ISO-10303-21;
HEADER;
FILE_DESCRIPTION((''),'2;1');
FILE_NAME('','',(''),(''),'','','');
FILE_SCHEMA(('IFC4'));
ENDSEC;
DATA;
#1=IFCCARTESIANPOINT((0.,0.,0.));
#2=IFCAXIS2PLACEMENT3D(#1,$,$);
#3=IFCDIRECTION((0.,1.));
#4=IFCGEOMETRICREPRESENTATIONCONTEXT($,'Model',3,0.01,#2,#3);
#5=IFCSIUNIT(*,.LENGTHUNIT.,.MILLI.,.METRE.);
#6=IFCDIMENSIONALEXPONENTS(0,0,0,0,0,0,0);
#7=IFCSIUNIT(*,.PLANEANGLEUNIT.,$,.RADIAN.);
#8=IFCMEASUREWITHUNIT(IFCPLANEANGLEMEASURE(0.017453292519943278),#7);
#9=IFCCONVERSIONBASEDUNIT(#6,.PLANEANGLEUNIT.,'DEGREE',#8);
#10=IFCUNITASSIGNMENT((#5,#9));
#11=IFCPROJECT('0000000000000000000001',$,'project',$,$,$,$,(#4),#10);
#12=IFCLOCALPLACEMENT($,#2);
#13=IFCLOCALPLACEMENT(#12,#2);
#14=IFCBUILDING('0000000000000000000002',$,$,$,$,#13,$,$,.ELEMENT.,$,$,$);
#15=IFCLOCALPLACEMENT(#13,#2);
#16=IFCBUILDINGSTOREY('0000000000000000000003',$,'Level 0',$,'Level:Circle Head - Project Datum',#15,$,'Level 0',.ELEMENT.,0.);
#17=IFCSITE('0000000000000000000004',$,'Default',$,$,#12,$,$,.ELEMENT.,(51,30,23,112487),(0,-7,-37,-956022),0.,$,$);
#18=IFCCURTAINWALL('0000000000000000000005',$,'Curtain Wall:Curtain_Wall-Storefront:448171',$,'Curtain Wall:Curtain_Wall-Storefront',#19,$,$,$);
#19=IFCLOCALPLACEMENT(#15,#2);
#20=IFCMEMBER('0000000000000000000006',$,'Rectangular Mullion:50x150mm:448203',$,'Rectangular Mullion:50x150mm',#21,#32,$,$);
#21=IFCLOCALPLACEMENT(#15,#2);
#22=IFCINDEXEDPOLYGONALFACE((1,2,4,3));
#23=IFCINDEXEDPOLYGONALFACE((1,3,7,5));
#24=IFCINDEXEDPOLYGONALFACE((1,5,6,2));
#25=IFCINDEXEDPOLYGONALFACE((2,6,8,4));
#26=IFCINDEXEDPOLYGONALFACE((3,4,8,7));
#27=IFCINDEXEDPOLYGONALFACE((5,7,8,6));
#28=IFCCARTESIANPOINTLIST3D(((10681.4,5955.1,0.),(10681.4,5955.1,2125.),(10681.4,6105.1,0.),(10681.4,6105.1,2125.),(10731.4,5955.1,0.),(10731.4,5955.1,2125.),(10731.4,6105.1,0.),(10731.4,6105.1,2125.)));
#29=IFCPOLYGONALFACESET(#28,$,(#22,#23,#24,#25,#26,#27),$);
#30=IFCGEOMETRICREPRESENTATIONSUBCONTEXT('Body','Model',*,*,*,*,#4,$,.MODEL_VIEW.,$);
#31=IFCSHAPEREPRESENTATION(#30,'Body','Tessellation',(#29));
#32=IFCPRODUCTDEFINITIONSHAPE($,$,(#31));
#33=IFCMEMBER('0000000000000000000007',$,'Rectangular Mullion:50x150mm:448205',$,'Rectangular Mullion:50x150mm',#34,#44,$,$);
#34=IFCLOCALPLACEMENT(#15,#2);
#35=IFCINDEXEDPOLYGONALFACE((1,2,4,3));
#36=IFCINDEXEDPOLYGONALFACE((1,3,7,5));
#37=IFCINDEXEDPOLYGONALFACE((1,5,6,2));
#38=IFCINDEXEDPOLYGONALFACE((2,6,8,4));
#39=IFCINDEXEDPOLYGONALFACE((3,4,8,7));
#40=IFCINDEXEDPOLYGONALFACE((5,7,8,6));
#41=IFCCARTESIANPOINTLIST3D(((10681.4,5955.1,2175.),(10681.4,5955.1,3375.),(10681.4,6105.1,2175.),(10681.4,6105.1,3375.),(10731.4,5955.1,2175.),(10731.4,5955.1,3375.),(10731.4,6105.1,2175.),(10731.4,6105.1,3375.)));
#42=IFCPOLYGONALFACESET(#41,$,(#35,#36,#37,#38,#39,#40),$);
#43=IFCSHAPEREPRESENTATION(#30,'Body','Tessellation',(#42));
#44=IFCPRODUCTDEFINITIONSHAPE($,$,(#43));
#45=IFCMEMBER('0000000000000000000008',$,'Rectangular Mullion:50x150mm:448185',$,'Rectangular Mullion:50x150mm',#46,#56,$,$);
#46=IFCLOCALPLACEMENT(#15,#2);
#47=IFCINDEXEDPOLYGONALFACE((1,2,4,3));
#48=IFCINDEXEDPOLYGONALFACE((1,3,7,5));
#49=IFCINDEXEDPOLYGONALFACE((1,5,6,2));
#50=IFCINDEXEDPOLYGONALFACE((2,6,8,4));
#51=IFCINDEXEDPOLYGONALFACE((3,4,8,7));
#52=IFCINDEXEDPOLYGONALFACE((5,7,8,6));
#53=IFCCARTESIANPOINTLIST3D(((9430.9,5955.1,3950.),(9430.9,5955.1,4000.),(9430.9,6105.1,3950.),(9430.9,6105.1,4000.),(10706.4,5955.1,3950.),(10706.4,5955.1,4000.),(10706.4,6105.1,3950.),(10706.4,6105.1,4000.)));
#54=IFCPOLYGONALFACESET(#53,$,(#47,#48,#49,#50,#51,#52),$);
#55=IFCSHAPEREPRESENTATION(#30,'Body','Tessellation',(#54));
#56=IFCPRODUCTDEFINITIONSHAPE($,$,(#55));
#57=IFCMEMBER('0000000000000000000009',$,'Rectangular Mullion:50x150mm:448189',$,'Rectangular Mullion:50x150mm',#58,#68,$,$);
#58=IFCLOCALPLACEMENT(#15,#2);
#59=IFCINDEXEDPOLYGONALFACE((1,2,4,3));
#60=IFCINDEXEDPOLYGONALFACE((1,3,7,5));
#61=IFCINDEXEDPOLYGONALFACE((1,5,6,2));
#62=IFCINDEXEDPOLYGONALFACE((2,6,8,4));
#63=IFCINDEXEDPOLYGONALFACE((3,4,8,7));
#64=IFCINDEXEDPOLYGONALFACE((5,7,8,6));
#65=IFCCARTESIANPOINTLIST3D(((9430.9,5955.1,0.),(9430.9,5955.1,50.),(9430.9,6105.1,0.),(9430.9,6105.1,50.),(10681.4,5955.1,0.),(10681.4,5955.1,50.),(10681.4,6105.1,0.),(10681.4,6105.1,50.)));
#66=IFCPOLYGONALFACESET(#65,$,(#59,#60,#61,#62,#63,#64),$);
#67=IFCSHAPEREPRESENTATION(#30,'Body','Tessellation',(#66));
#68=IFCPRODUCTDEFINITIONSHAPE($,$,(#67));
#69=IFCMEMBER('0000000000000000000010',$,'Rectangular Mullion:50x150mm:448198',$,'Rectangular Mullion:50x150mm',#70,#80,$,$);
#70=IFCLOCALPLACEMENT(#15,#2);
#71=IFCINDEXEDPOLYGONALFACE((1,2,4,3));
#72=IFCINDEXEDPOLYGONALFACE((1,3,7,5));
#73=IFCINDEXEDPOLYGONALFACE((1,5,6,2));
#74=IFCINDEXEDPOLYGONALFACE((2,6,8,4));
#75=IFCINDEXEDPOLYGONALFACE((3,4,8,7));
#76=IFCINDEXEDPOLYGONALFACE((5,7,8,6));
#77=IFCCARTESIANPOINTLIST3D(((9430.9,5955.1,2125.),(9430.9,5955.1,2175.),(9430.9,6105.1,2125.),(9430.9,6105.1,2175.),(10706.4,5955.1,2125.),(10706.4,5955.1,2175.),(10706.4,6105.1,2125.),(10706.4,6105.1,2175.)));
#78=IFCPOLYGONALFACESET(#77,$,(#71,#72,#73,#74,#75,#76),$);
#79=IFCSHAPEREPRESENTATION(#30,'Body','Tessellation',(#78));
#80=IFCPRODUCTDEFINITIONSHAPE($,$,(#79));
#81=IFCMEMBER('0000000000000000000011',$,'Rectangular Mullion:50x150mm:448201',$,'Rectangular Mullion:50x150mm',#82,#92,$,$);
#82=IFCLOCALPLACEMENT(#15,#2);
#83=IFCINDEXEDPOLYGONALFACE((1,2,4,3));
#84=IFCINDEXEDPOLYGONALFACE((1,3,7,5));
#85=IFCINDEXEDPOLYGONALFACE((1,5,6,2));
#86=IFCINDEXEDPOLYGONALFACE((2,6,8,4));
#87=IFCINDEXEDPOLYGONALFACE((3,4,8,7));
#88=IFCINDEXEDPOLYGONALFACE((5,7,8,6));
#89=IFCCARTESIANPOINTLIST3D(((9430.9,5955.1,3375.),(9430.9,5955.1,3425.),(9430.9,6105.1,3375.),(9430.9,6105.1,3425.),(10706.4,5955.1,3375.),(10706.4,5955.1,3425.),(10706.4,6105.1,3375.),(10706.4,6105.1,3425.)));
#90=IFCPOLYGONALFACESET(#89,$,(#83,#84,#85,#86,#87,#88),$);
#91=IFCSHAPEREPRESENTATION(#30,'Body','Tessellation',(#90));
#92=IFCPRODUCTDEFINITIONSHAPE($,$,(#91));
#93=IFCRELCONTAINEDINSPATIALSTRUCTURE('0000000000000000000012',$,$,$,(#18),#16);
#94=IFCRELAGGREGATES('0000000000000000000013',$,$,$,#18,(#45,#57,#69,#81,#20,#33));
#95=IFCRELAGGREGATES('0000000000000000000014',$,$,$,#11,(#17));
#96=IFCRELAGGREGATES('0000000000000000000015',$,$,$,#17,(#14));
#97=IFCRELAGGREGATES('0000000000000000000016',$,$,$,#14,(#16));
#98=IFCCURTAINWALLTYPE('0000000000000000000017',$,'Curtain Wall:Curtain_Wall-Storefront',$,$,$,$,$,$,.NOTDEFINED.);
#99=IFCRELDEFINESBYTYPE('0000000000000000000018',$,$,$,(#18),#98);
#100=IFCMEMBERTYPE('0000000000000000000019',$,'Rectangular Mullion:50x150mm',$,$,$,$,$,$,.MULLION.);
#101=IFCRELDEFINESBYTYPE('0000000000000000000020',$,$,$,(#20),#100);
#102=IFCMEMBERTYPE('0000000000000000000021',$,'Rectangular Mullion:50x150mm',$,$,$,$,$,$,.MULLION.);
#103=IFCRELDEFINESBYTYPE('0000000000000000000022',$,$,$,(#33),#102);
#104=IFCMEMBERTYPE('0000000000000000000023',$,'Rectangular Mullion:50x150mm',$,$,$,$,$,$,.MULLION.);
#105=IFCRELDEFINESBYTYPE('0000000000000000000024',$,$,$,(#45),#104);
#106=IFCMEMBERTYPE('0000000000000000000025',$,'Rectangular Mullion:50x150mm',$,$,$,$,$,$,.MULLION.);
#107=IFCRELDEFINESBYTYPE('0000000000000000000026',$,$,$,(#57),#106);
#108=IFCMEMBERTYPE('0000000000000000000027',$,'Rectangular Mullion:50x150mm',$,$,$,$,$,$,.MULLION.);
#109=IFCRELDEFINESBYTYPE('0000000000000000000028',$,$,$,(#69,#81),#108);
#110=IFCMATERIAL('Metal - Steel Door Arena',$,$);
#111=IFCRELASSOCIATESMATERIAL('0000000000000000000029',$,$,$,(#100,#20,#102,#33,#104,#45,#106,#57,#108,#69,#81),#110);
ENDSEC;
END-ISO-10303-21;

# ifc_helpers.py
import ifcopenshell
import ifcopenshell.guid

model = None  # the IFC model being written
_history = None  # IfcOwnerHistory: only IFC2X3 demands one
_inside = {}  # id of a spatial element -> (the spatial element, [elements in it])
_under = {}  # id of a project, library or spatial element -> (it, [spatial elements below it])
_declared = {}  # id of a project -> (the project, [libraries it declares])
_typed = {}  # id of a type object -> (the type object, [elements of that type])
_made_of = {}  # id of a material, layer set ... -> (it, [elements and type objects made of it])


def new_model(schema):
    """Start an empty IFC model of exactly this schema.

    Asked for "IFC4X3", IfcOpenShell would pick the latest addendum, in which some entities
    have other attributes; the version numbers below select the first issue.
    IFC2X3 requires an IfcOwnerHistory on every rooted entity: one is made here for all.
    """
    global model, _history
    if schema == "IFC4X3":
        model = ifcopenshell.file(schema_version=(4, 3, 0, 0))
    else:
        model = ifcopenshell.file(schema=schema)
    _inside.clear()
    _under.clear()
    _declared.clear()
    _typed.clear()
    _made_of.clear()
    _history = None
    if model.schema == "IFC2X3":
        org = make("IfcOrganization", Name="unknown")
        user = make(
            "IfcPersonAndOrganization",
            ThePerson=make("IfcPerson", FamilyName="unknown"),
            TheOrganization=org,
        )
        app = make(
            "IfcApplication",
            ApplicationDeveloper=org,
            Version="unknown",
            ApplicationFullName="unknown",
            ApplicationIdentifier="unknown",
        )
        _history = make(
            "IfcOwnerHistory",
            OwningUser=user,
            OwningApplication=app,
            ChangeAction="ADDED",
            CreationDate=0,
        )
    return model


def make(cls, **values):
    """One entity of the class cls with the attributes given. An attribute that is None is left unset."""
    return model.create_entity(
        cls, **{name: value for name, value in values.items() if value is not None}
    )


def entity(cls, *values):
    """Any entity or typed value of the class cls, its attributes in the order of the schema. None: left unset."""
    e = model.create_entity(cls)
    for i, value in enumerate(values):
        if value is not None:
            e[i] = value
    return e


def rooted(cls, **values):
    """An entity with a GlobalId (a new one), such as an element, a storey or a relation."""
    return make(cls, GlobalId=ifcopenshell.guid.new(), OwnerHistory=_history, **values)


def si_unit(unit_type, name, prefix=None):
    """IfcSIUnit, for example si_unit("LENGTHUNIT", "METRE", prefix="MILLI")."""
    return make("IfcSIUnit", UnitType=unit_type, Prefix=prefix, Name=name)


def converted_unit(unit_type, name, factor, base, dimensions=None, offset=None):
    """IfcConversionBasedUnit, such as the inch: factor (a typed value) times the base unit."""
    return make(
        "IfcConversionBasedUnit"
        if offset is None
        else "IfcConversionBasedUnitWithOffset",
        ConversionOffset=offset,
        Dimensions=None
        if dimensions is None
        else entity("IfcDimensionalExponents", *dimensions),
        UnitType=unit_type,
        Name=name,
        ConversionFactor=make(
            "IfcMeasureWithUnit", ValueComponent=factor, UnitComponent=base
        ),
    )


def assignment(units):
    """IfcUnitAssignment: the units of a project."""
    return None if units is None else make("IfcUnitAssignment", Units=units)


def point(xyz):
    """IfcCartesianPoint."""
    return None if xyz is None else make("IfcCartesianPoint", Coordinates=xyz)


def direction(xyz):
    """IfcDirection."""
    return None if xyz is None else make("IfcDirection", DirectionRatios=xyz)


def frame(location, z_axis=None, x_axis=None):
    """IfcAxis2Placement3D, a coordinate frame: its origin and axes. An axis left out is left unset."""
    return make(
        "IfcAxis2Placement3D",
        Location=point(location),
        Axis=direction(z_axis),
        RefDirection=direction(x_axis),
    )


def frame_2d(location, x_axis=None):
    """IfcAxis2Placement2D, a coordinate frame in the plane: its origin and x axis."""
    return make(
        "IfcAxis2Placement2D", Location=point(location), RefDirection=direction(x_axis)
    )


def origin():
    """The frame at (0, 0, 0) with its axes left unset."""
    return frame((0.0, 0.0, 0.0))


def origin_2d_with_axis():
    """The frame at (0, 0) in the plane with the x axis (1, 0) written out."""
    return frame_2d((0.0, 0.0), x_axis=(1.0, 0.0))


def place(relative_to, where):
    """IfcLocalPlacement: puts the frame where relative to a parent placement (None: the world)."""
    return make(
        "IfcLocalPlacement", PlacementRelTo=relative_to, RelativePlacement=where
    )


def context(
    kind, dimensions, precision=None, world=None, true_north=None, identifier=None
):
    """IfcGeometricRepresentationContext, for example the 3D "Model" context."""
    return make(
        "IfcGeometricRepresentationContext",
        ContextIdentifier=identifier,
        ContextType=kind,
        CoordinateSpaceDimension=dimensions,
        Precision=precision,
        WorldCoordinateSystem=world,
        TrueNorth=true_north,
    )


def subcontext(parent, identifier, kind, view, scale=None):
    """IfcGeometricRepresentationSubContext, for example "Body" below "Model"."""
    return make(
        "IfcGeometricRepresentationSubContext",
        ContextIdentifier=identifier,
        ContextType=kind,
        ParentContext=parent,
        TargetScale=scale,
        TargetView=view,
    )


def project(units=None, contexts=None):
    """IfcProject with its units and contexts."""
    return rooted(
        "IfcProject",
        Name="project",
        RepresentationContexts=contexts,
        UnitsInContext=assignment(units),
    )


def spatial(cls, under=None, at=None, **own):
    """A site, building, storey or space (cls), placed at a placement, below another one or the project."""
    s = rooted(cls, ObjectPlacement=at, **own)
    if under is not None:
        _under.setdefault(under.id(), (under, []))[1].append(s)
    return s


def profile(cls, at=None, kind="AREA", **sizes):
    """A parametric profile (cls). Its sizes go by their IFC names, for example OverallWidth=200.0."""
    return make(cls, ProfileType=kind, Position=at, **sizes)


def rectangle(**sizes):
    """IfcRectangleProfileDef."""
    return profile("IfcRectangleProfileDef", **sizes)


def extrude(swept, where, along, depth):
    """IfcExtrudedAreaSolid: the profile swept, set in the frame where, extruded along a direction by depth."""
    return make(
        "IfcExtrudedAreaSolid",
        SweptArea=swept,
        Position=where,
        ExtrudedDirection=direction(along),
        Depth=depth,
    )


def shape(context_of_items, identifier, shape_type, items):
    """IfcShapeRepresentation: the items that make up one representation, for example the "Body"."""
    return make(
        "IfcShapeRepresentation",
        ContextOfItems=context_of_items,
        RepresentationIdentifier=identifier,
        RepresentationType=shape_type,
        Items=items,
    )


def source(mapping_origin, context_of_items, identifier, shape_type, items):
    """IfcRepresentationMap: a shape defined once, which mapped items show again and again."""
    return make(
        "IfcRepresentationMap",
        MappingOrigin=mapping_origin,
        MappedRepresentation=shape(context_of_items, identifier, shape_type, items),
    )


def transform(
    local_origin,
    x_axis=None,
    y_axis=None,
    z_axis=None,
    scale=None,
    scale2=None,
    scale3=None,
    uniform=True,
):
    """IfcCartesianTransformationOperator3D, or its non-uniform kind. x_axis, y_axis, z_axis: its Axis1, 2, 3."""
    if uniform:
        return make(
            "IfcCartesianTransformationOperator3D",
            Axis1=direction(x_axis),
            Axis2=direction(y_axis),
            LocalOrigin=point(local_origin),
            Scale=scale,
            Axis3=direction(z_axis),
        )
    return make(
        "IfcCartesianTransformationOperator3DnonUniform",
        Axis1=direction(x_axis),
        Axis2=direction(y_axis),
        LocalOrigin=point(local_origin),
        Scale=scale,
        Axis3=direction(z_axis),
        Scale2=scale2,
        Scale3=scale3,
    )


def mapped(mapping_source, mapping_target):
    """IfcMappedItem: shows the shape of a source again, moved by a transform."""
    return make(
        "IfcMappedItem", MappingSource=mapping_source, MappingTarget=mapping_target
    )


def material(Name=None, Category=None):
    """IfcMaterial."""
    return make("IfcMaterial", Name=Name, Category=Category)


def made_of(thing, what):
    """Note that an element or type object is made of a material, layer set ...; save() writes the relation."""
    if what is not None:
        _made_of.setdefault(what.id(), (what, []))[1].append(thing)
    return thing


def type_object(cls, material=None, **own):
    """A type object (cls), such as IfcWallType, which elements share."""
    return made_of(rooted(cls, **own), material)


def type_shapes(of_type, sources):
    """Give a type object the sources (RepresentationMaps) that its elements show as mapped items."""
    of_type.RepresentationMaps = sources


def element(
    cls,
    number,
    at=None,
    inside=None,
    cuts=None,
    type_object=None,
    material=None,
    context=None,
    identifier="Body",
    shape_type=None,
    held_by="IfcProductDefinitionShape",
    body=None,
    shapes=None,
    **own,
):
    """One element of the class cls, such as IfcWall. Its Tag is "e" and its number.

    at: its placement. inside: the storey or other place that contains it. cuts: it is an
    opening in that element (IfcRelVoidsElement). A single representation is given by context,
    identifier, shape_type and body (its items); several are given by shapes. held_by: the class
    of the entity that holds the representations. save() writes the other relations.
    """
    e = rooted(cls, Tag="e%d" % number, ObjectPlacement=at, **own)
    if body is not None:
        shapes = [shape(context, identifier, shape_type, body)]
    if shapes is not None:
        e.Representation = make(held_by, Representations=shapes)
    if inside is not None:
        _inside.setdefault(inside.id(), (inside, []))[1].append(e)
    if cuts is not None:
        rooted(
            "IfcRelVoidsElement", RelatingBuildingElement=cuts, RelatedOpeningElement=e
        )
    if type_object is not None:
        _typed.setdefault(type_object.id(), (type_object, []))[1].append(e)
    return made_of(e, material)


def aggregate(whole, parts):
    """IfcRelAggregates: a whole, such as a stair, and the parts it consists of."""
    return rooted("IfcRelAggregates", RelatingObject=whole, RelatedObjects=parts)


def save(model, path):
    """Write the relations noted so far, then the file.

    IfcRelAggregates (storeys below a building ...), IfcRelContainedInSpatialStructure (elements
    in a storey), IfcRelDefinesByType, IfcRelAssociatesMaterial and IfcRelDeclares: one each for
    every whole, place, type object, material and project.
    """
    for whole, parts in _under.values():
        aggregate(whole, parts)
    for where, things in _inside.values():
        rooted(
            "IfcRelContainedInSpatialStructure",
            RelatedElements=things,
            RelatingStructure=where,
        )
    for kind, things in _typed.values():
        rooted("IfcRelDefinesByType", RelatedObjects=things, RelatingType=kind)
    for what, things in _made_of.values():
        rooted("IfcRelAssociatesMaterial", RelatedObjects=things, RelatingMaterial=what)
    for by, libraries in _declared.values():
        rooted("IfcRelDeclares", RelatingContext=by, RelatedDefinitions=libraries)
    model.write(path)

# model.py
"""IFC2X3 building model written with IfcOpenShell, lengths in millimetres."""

from ifc_helpers import new_model, entity, si_unit, converted_unit, direction, frame, origin, origin_2d_with_axis, place, context, subcontext, project, spatial, rectangle, extrude, source, transform, mapped, material, type_object, type_shapes, element, aggregate, save


model = new_model("IFC2X3")

# Units and contexts
model_context = context("Model", 3, precision=0.01, world=origin(), true_north=direction((0.0, 1.0)))
body_context = subcontext(model_context, "Body", "Model", "MODEL_VIEW")
ifc_project = project(units=[si_unit("LENGTHUNIT", "METRE", prefix="MILLI"), converted_unit("PLANEANGLEUNIT", "DEGREE", entity("IfcPlaneAngleMeasure", 0.017453292519943278), si_unit("PLANEANGLEUNIT", "RADIAN"), dimensions=[0, 0, 0, 0, 0, 0, 0])], contexts=[model_context])

# Site, building, storey
site_placement = place(None, origin())
site = spatial("IfcSite", under=ifc_project, at=site_placement, Name="Default", CompositionType="ELEMENT", RefLatitude=(51, 30, 23, 112487), RefLongitude=(0, -7, -37, -956022), RefElevation=0.0)
building_placement = place(site_placement, origin())
building = spatial("IfcBuilding", under=site, at=building_placement, CompositionType="ELEMENT")
storey_placement = place(building_placement, origin())
storey = spatial("IfcBuildingStorey", under=building, at=storey_placement, Name="Level 0", ObjectType="Level:Circle Head - Project Datum", LongName="Level 0", CompositionType="ELEMENT", Elevation=0.0)

# Curtain wall
curtain_wall_type = type_object("IfcCurtainWallType", Name="Curtain Wall:Curtain_Wall-Storefront", PredefinedType="NOTDEFINED")
curtain_wall_1_placement = place(storey_placement, origin())
curtain_wall_1 = element("IfcCurtainWall", 1, at=curtain_wall_1_placement, inside=storey, type_object=curtain_wall_type, Name="Curtain Wall:Curtain_Wall-Storefront:448171", ObjectType="Curtain Wall:Curtain_Wall-Storefront")
ifc_material_1 = material(Name="Metal - Steel Door Arena")

# Members
member_type_1 = type_object("IfcMemberType", Name="Rectangular Mullion:50x150mm", PredefinedType="MULLION", material=ifc_material_1)
shared_shape_1 = source(origin(), body_context, "Body", "SweptSolid", [
    extrude(rectangle(XDim=50.0, YDim=150.0, at=origin_2d_with_axis()), frame((0.0, 0.0, -2125.0), z_axis=(0.0, 0.0, 1.0), x_axis=(-1.0, 0.0, 0.0)), (0.0, 0.0, 1.0), 2125.0),
])
type_shapes(member_type_1, [shared_shape_1])
member_1_placement = place(curtain_wall_1_placement, frame((10706.4, 6030.1, 0.0), z_axis=(0.0, 0.0, -1.0), x_axis=(-1.0, 0.0, 0.0)))
member_1 = element("IfcMember", 2, at=member_1_placement, type_object=member_type_1, material=ifc_material_1, Name="Rectangular Mullion:50x150mm:448203", ObjectType="Rectangular Mullion:50x150mm", context=body_context, shape_type="MappedRepresentation", body=[
    mapped(shared_shape_1, transform((0.0, 0.0, 0.0), scale=1.0)),
])
member_type_2 = type_object("IfcMemberType", Name="Rectangular Mullion:50x150mm", PredefinedType="MULLION", material=ifc_material_1)
shared_shape_2 = source(origin(), body_context, "Body", "SweptSolid", [
    extrude(rectangle(XDim=50.0, YDim=150.0, at=origin_2d_with_axis()), frame((0.0, 0.0, -1200.0), z_axis=(0.0, 0.0, 1.0), x_axis=(-1.0, 0.0, 0.0)), (0.0, 0.0, 1.0), 1200.0),
])
type_shapes(member_type_2, [shared_shape_2])
member_2_placement = place(curtain_wall_1_placement, frame((10706.4, 6030.1, 2175.0), z_axis=(0.0, 0.0, -1.0), x_axis=(-1.0, 0.0, 0.0)))
member_2 = element("IfcMember", 3, at=member_2_placement, type_object=member_type_2, material=ifc_material_1, Name="Rectangular Mullion:50x150mm:448205", ObjectType="Rectangular Mullion:50x150mm", context=body_context, shape_type="MappedRepresentation", body=[
    mapped(shared_shape_2, transform((0.0, 0.0, 0.0), scale=1.0)),
])
member_type_3 = type_object("IfcMemberType", Name="Rectangular Mullion:50x150mm", PredefinedType="MULLION", material=ifc_material_1)
shared_shape_3 = source(origin(), body_context, "Body", "SweptSolid", [
    extrude(rectangle(XDim=50.0, YDim=150.0, at=origin_2d_with_axis()), frame((-25.0, 0.0, -1275.5), z_axis=(0.0, 0.0, 1.0), x_axis=(-1.0, 0.0, 0.0)), (0.0, 0.0, 1.0), 1275.5),
])
type_shapes(member_type_3, [shared_shape_3])
member_3_placement = place(curtain_wall_1_placement, frame((9430.9, 6030.1, 4000.0), z_axis=(-1.0, 0.0, 0.0), x_axis=(0.0, 0.0, 1.0)))
member_3 = element("IfcMember", 4, at=member_3_placement, type_object=member_type_3, material=ifc_material_1, Name="Rectangular Mullion:50x150mm:448185", ObjectType="Rectangular Mullion:50x150mm", context=body_context, shape_type="MappedRepresentation", body=[
    mapped(shared_shape_3, transform((0.0, 0.0, 0.0), scale=1.0)),
])
member_type_4 = type_object("IfcMemberType", Name="Rectangular Mullion:50x150mm", PredefinedType="MULLION", material=ifc_material_1)
shared_shape_4 = source(origin(), body_context, "Body", "SweptSolid", [
    extrude(rectangle(XDim=50.0, YDim=150.0, at=origin_2d_with_axis()), frame((-25.0, 0.0, -1250.5), z_axis=(0.0, 0.0, 1.0), x_axis=(-1.0, 0.0, 0.0)), (0.0, 0.0, 1.0), 1250.5),
])
type_shapes(member_type_4, [shared_shape_4])
member_4_placement = place(curtain_wall_1_placement, frame((10681.4, 6030.1, 0.0), z_axis=(1.0, 0.0, 0.0), x_axis=(0.0, 0.0, -1.0)))
member_4 = element("IfcMember", 5, at=member_4_placement, type_object=member_type_4, material=ifc_material_1, Name="Rectangular Mullion:50x150mm:448189", ObjectType="Rectangular Mullion:50x150mm", context=body_context, shape_type="MappedRepresentation", body=[
    mapped(shared_shape_4, transform((0.0, 0.0, 0.0), scale=1.0)),
])
member_type_5 = type_object("IfcMemberType", Name="Rectangular Mullion:50x150mm", PredefinedType="MULLION", material=ifc_material_1)
shared_shape_5 = source(origin(), body_context, "Body", "SweptSolid", [
    extrude(rectangle(XDim=50.0, YDim=150.0, at=origin_2d_with_axis()), frame((0.0, 0.0, -1275.5), z_axis=(0.0, 0.0, 1.0), x_axis=(-1.0, 0.0, 0.0)), (0.0, 0.0, 1.0), 1275.5),
])
type_shapes(member_type_5, [shared_shape_5])
member_5_placement = place(curtain_wall_1_placement, frame((9430.9, 6030.1, 2150.0), z_axis=(-1.0, 0.0, 0.0), x_axis=(0.0, 0.0, 1.0)))
member_5 = element("IfcMember", 6, at=member_5_placement, type_object=member_type_5, material=ifc_material_1, Name="Rectangular Mullion:50x150mm:448198", ObjectType="Rectangular Mullion:50x150mm", context=body_context, shape_type="MappedRepresentation", body=[
    mapped(shared_shape_5, transform((0.0, 0.0, 0.0), scale=1.0)),
])
member_6_placement = place(curtain_wall_1_placement, frame((9430.9, 6030.1, 3400.0), z_axis=(-1.0, 0.0, 0.0), x_axis=(0.0, 0.0, 1.0)))
member_6 = element("IfcMember", 7, at=member_6_placement, type_object=member_type_5, material=ifc_material_1, Name="Rectangular Mullion:50x150mm:448201", ObjectType="Rectangular Mullion:50x150mm", context=body_context, shape_type="MappedRepresentation", body=[
    mapped(shared_shape_5, transform((0.0, 0.0, 0.0), scale=1.0)),
])

aggregate(curtain_wall_1, [member_3, member_4, member_5, member_6, member_1, member_2])

save(model, "model.ifc")
